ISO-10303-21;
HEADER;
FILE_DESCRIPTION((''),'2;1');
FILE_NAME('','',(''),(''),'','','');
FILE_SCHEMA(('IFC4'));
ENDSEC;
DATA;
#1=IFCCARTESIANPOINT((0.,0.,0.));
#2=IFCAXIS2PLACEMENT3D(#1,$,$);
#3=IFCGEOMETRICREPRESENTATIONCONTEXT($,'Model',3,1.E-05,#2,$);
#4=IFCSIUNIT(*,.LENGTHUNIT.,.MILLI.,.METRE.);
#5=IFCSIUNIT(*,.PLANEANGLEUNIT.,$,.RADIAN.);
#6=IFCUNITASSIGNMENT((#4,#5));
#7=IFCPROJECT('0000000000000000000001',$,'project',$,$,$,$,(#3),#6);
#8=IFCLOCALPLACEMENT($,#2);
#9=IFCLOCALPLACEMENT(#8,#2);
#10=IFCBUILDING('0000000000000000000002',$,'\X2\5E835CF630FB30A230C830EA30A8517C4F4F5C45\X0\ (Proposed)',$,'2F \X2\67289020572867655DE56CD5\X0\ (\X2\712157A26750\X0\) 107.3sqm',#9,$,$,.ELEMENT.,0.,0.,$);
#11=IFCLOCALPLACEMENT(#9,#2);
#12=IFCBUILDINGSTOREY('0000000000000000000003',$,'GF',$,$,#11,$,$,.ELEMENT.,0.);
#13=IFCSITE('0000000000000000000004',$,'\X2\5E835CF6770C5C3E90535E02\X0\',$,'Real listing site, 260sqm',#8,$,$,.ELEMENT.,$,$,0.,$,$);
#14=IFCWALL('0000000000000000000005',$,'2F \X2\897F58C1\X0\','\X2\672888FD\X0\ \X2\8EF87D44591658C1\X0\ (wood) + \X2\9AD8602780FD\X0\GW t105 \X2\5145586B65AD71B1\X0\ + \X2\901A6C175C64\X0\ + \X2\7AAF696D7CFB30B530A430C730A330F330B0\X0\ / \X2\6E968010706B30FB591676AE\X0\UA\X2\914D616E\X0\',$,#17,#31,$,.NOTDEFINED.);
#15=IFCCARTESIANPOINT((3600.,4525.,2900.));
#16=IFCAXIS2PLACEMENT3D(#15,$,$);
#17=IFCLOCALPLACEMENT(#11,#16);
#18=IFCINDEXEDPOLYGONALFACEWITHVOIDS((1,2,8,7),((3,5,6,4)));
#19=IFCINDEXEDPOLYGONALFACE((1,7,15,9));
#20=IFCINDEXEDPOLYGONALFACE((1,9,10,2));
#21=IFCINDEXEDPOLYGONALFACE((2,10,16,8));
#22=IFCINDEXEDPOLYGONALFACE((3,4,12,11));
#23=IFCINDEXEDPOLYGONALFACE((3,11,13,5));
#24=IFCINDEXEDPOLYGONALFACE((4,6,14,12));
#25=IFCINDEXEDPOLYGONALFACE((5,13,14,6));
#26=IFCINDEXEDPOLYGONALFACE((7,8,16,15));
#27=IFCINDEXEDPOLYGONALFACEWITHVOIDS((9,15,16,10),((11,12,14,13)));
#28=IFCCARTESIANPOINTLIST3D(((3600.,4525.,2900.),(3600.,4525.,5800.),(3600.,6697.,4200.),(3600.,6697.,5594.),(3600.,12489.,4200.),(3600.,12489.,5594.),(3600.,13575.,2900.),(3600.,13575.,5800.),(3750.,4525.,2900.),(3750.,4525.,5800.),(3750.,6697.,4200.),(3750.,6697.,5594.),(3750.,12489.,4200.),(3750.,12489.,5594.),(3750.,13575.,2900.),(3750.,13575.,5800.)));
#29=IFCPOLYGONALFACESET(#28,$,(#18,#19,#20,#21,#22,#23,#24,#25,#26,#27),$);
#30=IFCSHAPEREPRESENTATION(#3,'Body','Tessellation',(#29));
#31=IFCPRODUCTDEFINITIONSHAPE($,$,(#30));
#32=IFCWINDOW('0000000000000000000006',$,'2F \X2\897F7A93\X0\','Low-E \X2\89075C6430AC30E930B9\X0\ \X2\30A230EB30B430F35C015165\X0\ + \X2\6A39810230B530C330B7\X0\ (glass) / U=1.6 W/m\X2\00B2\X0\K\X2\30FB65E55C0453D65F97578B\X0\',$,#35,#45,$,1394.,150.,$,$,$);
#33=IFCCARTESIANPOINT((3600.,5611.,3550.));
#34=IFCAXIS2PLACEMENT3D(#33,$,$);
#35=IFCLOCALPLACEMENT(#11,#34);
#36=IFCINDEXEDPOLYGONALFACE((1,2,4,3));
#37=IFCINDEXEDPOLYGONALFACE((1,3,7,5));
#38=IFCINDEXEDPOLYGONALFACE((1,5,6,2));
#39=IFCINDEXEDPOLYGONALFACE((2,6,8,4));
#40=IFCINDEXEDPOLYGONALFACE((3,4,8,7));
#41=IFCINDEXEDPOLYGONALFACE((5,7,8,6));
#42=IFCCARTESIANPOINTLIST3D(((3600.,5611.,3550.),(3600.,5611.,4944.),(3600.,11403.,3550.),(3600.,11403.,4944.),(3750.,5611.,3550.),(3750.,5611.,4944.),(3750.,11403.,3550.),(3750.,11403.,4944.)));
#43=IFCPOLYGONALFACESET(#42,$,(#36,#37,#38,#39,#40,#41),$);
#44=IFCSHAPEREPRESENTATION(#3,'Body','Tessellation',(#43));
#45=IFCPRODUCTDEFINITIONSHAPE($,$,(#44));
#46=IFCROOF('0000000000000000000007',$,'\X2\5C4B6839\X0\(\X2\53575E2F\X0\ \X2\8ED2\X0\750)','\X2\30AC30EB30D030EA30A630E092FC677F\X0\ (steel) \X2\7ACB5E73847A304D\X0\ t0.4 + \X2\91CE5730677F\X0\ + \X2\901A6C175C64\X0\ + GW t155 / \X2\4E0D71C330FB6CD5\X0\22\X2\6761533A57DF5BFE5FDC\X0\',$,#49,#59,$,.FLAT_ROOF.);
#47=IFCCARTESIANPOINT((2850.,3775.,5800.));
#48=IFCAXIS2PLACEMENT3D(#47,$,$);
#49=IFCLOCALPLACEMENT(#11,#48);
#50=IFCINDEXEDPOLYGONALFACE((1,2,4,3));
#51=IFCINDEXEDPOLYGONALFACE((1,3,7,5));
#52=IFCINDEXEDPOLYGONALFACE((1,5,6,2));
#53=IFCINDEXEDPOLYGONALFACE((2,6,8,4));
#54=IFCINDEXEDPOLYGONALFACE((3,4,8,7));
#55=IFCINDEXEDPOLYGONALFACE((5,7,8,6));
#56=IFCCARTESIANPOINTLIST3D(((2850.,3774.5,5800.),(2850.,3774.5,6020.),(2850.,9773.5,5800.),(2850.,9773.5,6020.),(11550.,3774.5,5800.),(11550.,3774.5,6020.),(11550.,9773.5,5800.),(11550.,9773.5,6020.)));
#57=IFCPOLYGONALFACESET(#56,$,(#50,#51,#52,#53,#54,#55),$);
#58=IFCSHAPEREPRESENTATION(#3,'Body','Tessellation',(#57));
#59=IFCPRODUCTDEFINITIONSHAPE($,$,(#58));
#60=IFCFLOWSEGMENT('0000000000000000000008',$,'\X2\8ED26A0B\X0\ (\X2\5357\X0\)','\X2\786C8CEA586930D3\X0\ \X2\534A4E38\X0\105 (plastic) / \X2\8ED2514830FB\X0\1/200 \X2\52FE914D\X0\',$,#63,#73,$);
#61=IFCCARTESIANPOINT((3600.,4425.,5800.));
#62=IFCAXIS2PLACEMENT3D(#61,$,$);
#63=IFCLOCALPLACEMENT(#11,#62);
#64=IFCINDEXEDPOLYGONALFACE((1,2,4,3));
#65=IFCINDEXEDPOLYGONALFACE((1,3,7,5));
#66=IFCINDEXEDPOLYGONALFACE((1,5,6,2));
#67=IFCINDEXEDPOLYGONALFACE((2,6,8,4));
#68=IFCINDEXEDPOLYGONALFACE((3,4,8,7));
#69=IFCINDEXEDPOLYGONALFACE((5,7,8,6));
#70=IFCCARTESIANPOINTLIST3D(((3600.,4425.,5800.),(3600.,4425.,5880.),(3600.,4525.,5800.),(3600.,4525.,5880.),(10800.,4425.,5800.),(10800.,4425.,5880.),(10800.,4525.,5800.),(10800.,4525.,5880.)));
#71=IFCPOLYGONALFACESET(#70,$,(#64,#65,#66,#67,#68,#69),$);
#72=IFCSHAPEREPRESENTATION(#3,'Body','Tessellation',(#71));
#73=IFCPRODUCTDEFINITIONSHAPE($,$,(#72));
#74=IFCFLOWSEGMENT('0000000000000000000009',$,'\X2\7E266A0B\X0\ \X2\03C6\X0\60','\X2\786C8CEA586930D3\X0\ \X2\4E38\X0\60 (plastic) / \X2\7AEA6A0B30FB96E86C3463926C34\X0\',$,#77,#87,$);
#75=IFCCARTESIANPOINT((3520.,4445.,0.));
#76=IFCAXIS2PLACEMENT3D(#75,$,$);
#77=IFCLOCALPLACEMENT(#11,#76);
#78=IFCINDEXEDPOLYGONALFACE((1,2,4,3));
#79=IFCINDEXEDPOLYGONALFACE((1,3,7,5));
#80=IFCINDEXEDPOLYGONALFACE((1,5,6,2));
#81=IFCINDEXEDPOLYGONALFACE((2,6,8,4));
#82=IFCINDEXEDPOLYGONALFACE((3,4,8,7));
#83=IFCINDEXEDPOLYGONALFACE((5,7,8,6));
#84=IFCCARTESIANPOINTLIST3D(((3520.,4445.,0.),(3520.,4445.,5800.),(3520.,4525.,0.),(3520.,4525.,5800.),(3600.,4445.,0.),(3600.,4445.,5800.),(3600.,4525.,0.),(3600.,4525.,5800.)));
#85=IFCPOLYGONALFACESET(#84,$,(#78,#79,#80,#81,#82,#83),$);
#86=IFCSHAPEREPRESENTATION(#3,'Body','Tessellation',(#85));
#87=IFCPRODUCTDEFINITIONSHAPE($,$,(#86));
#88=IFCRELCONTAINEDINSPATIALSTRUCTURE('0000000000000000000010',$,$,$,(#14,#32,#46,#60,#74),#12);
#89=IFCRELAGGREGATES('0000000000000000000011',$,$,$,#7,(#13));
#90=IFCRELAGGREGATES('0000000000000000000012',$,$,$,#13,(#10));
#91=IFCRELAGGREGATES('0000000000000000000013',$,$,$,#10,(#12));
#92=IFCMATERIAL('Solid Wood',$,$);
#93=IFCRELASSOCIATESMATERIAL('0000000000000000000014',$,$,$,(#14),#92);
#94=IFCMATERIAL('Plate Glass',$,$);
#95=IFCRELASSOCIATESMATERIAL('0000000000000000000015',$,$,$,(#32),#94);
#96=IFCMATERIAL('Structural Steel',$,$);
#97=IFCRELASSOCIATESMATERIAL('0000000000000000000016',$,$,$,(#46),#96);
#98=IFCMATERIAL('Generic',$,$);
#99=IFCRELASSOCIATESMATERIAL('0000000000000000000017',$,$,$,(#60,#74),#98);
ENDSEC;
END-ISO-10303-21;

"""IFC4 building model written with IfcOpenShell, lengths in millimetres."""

from ifc_helpers import new_model, si_unit, frame, frame_2d, origin, place, context, project, spatial, rectangle, extrude, material, element, fill, save


model = new_model("IFC4")

# Units and contexts
model_context = context("Model", 3, precision=1e-05, world=origin())
ifc_project = project(units=[si_unit("LENGTHUNIT", "METRE", prefix="MILLI"), si_unit("PLANEANGLEUNIT", "RADIAN")], contexts=[model_context])

# Site, building, storey
site_placement = place(None, origin())
site = spatial("IfcSite", under=ifc_project, at=site_placement, Name="広島県尾道市", ObjectType="Real listing site, 260sqm", CompositionType="ELEMENT", RefElevation=0.0)
building_placement = place(site_placement, origin())
building = spatial("IfcBuilding", under=site, at=building_placement, Name="広島・アトリエ兼住居 (Proposed)", ObjectType="2F 木造在来工法 (無垢材) 107.3sqm", CompositionType="ELEMENT", ElevationOfRefHeight=0.0, ElevationOfTerrain=0.0)
storey_placement = place(building_placement, origin())
storey = spatial("IfcBuildingStorey", under=building, at=storey_placement, Name="GF", CompositionType="ELEMENT", Elevation=0.0)

# Shared definitions
ifc_material_1 = material(Name="Solid Wood")

# Shared definitions
ifc_material_2 = material(Name="Plate Glass")

# Wall, opening, window
wall_1_placement = place(storey_placement, frame((3600.0, 4525.0, 2900.0)))
wall_1 = element("IfcWall", 1, at=wall_1_placement, inside=storey, material=ifc_material_1, Name="2F 西壁", Description="木製 軸組外壁 (wood) + 高性能GW t105 充填断熱 + 通気層 + 窯業系サイディング / 準耐火・外皮UA配慮", PredefinedType="NOTDEFINED", context=model_context, shape_type="SweptSolid", body=[
    extrude(rectangle(XDim=150.0, YDim=9050.0, at=frame_2d((75.0, 4525.0))), frame((3600.0, 4525.0, 2900.0)), (0.0, 0.0, 1.0), 2900.0),
])
opening_1_placement = place(storey_placement, frame((3600.0, 5611.0, 3550.0)))
opening_1 = element("IfcOpeningElement", 2, at=opening_1_placement, cuts=wall_1, PredefinedType="NOTDEFINED", context=model_context, shape_type="SweptSolid", body=[
    extrude(rectangle(XDim=150.0, YDim=5792.0, at=frame_2d((75.0, 2896.0))), frame((3600.0, 5611.0, 3550.0)), (0.0, 0.0, 1.0), 1394.0),
])
window_1_placement = place(storey_placement, frame((3600.0, 5611.0, 3550.0)))
window_1 = element("IfcWindow", 3, at=window_1_placement, inside=storey, material=ifc_material_2, Name="2F 西窓", Description="Low-E 複層ガラス アルゴン封入 + 樹脂サッシ (glass) / U=1.6 W/m²K・日射取得型", OverallHeight=1394.0, OverallWidth=150.0, context=model_context, shape_type="SweptSolid", body=[
    extrude(rectangle(XDim=150.0, YDim=5792.0, at=frame_2d((75.0, 2896.0))), frame((3600.0, 5611.0, 3550.0)), (0.0, 0.0, 1.0), 1394.0),
])
fill(opening_1, window_1)

# Roof
ifc_material_3 = material(Name="Structural Steel")
for number, where, name in (
    (4, (2850.0, 3775.0, 5800.0), "屋根(南帯 軒750)"),
):
    element("IfcRoof", number, at=place(storey_placement, frame(where)), inside=storey, material=ifc_material_3, Name=name, Description="ガルバリウム鋼板 (steel) 立平葺き t0.4 + 野地板 + 通気層 + GW t155 / 不燃・法22条区域対応", PredefinedType="FLAT_ROOF", context=model_context, shape_type="SweptSolid", body=[
        extrude(rectangle(XDim=8700.0, YDim=5999.0, at=frame_2d((4350.0, 2999.0))), frame((2850.0, 3775.0, 5800.0)), (0.0, 0.0, 1.0), 220.0),
    ])

# Flow segments
ifc_material_4 = material(Name="Generic")
flow_segment_1_placement = place(storey_placement, frame((3600.0, 4425.0, 5800.0)))
element("IfcFlowSegment", 5, at=flow_segment_1_placement, inside=storey, material=ifc_material_4, Name="軒樋 (南)", Description="硬質塩ビ 半丸105 (plastic) / 軒先・1/200 勾配", context=model_context, shape_type="SweptSolid", body=[
    extrude(rectangle(XDim=7200.0, YDim=100.0, at=frame_2d((3600.0, 50.0))), frame((3600.0, 4425.0, 5800.0)), (0.0, 0.0, 1.0), 80.0),
])
flow_segment_2_placement = place(storey_placement, frame((3520.0, 4445.0, 0.0)))
element("IfcFlowSegment", 6, at=flow_segment_2_placement, inside=storey, material=ifc_material_4, Name="縦樋 φ60", Description="硬質塩ビ 丸60 (plastic) / 竪樋・雨水排水", context=model_context, shape_type="SweptSolid", body=[
    extrude(rectangle(XDim=80.0, YDim=80.0, at=frame_2d((40.0, 40.0))), frame((3520.0, 4445.0, 0.0)), (0.0, 0.0, 1.0), 5800.0),
])

save(model, "model.ifc")
